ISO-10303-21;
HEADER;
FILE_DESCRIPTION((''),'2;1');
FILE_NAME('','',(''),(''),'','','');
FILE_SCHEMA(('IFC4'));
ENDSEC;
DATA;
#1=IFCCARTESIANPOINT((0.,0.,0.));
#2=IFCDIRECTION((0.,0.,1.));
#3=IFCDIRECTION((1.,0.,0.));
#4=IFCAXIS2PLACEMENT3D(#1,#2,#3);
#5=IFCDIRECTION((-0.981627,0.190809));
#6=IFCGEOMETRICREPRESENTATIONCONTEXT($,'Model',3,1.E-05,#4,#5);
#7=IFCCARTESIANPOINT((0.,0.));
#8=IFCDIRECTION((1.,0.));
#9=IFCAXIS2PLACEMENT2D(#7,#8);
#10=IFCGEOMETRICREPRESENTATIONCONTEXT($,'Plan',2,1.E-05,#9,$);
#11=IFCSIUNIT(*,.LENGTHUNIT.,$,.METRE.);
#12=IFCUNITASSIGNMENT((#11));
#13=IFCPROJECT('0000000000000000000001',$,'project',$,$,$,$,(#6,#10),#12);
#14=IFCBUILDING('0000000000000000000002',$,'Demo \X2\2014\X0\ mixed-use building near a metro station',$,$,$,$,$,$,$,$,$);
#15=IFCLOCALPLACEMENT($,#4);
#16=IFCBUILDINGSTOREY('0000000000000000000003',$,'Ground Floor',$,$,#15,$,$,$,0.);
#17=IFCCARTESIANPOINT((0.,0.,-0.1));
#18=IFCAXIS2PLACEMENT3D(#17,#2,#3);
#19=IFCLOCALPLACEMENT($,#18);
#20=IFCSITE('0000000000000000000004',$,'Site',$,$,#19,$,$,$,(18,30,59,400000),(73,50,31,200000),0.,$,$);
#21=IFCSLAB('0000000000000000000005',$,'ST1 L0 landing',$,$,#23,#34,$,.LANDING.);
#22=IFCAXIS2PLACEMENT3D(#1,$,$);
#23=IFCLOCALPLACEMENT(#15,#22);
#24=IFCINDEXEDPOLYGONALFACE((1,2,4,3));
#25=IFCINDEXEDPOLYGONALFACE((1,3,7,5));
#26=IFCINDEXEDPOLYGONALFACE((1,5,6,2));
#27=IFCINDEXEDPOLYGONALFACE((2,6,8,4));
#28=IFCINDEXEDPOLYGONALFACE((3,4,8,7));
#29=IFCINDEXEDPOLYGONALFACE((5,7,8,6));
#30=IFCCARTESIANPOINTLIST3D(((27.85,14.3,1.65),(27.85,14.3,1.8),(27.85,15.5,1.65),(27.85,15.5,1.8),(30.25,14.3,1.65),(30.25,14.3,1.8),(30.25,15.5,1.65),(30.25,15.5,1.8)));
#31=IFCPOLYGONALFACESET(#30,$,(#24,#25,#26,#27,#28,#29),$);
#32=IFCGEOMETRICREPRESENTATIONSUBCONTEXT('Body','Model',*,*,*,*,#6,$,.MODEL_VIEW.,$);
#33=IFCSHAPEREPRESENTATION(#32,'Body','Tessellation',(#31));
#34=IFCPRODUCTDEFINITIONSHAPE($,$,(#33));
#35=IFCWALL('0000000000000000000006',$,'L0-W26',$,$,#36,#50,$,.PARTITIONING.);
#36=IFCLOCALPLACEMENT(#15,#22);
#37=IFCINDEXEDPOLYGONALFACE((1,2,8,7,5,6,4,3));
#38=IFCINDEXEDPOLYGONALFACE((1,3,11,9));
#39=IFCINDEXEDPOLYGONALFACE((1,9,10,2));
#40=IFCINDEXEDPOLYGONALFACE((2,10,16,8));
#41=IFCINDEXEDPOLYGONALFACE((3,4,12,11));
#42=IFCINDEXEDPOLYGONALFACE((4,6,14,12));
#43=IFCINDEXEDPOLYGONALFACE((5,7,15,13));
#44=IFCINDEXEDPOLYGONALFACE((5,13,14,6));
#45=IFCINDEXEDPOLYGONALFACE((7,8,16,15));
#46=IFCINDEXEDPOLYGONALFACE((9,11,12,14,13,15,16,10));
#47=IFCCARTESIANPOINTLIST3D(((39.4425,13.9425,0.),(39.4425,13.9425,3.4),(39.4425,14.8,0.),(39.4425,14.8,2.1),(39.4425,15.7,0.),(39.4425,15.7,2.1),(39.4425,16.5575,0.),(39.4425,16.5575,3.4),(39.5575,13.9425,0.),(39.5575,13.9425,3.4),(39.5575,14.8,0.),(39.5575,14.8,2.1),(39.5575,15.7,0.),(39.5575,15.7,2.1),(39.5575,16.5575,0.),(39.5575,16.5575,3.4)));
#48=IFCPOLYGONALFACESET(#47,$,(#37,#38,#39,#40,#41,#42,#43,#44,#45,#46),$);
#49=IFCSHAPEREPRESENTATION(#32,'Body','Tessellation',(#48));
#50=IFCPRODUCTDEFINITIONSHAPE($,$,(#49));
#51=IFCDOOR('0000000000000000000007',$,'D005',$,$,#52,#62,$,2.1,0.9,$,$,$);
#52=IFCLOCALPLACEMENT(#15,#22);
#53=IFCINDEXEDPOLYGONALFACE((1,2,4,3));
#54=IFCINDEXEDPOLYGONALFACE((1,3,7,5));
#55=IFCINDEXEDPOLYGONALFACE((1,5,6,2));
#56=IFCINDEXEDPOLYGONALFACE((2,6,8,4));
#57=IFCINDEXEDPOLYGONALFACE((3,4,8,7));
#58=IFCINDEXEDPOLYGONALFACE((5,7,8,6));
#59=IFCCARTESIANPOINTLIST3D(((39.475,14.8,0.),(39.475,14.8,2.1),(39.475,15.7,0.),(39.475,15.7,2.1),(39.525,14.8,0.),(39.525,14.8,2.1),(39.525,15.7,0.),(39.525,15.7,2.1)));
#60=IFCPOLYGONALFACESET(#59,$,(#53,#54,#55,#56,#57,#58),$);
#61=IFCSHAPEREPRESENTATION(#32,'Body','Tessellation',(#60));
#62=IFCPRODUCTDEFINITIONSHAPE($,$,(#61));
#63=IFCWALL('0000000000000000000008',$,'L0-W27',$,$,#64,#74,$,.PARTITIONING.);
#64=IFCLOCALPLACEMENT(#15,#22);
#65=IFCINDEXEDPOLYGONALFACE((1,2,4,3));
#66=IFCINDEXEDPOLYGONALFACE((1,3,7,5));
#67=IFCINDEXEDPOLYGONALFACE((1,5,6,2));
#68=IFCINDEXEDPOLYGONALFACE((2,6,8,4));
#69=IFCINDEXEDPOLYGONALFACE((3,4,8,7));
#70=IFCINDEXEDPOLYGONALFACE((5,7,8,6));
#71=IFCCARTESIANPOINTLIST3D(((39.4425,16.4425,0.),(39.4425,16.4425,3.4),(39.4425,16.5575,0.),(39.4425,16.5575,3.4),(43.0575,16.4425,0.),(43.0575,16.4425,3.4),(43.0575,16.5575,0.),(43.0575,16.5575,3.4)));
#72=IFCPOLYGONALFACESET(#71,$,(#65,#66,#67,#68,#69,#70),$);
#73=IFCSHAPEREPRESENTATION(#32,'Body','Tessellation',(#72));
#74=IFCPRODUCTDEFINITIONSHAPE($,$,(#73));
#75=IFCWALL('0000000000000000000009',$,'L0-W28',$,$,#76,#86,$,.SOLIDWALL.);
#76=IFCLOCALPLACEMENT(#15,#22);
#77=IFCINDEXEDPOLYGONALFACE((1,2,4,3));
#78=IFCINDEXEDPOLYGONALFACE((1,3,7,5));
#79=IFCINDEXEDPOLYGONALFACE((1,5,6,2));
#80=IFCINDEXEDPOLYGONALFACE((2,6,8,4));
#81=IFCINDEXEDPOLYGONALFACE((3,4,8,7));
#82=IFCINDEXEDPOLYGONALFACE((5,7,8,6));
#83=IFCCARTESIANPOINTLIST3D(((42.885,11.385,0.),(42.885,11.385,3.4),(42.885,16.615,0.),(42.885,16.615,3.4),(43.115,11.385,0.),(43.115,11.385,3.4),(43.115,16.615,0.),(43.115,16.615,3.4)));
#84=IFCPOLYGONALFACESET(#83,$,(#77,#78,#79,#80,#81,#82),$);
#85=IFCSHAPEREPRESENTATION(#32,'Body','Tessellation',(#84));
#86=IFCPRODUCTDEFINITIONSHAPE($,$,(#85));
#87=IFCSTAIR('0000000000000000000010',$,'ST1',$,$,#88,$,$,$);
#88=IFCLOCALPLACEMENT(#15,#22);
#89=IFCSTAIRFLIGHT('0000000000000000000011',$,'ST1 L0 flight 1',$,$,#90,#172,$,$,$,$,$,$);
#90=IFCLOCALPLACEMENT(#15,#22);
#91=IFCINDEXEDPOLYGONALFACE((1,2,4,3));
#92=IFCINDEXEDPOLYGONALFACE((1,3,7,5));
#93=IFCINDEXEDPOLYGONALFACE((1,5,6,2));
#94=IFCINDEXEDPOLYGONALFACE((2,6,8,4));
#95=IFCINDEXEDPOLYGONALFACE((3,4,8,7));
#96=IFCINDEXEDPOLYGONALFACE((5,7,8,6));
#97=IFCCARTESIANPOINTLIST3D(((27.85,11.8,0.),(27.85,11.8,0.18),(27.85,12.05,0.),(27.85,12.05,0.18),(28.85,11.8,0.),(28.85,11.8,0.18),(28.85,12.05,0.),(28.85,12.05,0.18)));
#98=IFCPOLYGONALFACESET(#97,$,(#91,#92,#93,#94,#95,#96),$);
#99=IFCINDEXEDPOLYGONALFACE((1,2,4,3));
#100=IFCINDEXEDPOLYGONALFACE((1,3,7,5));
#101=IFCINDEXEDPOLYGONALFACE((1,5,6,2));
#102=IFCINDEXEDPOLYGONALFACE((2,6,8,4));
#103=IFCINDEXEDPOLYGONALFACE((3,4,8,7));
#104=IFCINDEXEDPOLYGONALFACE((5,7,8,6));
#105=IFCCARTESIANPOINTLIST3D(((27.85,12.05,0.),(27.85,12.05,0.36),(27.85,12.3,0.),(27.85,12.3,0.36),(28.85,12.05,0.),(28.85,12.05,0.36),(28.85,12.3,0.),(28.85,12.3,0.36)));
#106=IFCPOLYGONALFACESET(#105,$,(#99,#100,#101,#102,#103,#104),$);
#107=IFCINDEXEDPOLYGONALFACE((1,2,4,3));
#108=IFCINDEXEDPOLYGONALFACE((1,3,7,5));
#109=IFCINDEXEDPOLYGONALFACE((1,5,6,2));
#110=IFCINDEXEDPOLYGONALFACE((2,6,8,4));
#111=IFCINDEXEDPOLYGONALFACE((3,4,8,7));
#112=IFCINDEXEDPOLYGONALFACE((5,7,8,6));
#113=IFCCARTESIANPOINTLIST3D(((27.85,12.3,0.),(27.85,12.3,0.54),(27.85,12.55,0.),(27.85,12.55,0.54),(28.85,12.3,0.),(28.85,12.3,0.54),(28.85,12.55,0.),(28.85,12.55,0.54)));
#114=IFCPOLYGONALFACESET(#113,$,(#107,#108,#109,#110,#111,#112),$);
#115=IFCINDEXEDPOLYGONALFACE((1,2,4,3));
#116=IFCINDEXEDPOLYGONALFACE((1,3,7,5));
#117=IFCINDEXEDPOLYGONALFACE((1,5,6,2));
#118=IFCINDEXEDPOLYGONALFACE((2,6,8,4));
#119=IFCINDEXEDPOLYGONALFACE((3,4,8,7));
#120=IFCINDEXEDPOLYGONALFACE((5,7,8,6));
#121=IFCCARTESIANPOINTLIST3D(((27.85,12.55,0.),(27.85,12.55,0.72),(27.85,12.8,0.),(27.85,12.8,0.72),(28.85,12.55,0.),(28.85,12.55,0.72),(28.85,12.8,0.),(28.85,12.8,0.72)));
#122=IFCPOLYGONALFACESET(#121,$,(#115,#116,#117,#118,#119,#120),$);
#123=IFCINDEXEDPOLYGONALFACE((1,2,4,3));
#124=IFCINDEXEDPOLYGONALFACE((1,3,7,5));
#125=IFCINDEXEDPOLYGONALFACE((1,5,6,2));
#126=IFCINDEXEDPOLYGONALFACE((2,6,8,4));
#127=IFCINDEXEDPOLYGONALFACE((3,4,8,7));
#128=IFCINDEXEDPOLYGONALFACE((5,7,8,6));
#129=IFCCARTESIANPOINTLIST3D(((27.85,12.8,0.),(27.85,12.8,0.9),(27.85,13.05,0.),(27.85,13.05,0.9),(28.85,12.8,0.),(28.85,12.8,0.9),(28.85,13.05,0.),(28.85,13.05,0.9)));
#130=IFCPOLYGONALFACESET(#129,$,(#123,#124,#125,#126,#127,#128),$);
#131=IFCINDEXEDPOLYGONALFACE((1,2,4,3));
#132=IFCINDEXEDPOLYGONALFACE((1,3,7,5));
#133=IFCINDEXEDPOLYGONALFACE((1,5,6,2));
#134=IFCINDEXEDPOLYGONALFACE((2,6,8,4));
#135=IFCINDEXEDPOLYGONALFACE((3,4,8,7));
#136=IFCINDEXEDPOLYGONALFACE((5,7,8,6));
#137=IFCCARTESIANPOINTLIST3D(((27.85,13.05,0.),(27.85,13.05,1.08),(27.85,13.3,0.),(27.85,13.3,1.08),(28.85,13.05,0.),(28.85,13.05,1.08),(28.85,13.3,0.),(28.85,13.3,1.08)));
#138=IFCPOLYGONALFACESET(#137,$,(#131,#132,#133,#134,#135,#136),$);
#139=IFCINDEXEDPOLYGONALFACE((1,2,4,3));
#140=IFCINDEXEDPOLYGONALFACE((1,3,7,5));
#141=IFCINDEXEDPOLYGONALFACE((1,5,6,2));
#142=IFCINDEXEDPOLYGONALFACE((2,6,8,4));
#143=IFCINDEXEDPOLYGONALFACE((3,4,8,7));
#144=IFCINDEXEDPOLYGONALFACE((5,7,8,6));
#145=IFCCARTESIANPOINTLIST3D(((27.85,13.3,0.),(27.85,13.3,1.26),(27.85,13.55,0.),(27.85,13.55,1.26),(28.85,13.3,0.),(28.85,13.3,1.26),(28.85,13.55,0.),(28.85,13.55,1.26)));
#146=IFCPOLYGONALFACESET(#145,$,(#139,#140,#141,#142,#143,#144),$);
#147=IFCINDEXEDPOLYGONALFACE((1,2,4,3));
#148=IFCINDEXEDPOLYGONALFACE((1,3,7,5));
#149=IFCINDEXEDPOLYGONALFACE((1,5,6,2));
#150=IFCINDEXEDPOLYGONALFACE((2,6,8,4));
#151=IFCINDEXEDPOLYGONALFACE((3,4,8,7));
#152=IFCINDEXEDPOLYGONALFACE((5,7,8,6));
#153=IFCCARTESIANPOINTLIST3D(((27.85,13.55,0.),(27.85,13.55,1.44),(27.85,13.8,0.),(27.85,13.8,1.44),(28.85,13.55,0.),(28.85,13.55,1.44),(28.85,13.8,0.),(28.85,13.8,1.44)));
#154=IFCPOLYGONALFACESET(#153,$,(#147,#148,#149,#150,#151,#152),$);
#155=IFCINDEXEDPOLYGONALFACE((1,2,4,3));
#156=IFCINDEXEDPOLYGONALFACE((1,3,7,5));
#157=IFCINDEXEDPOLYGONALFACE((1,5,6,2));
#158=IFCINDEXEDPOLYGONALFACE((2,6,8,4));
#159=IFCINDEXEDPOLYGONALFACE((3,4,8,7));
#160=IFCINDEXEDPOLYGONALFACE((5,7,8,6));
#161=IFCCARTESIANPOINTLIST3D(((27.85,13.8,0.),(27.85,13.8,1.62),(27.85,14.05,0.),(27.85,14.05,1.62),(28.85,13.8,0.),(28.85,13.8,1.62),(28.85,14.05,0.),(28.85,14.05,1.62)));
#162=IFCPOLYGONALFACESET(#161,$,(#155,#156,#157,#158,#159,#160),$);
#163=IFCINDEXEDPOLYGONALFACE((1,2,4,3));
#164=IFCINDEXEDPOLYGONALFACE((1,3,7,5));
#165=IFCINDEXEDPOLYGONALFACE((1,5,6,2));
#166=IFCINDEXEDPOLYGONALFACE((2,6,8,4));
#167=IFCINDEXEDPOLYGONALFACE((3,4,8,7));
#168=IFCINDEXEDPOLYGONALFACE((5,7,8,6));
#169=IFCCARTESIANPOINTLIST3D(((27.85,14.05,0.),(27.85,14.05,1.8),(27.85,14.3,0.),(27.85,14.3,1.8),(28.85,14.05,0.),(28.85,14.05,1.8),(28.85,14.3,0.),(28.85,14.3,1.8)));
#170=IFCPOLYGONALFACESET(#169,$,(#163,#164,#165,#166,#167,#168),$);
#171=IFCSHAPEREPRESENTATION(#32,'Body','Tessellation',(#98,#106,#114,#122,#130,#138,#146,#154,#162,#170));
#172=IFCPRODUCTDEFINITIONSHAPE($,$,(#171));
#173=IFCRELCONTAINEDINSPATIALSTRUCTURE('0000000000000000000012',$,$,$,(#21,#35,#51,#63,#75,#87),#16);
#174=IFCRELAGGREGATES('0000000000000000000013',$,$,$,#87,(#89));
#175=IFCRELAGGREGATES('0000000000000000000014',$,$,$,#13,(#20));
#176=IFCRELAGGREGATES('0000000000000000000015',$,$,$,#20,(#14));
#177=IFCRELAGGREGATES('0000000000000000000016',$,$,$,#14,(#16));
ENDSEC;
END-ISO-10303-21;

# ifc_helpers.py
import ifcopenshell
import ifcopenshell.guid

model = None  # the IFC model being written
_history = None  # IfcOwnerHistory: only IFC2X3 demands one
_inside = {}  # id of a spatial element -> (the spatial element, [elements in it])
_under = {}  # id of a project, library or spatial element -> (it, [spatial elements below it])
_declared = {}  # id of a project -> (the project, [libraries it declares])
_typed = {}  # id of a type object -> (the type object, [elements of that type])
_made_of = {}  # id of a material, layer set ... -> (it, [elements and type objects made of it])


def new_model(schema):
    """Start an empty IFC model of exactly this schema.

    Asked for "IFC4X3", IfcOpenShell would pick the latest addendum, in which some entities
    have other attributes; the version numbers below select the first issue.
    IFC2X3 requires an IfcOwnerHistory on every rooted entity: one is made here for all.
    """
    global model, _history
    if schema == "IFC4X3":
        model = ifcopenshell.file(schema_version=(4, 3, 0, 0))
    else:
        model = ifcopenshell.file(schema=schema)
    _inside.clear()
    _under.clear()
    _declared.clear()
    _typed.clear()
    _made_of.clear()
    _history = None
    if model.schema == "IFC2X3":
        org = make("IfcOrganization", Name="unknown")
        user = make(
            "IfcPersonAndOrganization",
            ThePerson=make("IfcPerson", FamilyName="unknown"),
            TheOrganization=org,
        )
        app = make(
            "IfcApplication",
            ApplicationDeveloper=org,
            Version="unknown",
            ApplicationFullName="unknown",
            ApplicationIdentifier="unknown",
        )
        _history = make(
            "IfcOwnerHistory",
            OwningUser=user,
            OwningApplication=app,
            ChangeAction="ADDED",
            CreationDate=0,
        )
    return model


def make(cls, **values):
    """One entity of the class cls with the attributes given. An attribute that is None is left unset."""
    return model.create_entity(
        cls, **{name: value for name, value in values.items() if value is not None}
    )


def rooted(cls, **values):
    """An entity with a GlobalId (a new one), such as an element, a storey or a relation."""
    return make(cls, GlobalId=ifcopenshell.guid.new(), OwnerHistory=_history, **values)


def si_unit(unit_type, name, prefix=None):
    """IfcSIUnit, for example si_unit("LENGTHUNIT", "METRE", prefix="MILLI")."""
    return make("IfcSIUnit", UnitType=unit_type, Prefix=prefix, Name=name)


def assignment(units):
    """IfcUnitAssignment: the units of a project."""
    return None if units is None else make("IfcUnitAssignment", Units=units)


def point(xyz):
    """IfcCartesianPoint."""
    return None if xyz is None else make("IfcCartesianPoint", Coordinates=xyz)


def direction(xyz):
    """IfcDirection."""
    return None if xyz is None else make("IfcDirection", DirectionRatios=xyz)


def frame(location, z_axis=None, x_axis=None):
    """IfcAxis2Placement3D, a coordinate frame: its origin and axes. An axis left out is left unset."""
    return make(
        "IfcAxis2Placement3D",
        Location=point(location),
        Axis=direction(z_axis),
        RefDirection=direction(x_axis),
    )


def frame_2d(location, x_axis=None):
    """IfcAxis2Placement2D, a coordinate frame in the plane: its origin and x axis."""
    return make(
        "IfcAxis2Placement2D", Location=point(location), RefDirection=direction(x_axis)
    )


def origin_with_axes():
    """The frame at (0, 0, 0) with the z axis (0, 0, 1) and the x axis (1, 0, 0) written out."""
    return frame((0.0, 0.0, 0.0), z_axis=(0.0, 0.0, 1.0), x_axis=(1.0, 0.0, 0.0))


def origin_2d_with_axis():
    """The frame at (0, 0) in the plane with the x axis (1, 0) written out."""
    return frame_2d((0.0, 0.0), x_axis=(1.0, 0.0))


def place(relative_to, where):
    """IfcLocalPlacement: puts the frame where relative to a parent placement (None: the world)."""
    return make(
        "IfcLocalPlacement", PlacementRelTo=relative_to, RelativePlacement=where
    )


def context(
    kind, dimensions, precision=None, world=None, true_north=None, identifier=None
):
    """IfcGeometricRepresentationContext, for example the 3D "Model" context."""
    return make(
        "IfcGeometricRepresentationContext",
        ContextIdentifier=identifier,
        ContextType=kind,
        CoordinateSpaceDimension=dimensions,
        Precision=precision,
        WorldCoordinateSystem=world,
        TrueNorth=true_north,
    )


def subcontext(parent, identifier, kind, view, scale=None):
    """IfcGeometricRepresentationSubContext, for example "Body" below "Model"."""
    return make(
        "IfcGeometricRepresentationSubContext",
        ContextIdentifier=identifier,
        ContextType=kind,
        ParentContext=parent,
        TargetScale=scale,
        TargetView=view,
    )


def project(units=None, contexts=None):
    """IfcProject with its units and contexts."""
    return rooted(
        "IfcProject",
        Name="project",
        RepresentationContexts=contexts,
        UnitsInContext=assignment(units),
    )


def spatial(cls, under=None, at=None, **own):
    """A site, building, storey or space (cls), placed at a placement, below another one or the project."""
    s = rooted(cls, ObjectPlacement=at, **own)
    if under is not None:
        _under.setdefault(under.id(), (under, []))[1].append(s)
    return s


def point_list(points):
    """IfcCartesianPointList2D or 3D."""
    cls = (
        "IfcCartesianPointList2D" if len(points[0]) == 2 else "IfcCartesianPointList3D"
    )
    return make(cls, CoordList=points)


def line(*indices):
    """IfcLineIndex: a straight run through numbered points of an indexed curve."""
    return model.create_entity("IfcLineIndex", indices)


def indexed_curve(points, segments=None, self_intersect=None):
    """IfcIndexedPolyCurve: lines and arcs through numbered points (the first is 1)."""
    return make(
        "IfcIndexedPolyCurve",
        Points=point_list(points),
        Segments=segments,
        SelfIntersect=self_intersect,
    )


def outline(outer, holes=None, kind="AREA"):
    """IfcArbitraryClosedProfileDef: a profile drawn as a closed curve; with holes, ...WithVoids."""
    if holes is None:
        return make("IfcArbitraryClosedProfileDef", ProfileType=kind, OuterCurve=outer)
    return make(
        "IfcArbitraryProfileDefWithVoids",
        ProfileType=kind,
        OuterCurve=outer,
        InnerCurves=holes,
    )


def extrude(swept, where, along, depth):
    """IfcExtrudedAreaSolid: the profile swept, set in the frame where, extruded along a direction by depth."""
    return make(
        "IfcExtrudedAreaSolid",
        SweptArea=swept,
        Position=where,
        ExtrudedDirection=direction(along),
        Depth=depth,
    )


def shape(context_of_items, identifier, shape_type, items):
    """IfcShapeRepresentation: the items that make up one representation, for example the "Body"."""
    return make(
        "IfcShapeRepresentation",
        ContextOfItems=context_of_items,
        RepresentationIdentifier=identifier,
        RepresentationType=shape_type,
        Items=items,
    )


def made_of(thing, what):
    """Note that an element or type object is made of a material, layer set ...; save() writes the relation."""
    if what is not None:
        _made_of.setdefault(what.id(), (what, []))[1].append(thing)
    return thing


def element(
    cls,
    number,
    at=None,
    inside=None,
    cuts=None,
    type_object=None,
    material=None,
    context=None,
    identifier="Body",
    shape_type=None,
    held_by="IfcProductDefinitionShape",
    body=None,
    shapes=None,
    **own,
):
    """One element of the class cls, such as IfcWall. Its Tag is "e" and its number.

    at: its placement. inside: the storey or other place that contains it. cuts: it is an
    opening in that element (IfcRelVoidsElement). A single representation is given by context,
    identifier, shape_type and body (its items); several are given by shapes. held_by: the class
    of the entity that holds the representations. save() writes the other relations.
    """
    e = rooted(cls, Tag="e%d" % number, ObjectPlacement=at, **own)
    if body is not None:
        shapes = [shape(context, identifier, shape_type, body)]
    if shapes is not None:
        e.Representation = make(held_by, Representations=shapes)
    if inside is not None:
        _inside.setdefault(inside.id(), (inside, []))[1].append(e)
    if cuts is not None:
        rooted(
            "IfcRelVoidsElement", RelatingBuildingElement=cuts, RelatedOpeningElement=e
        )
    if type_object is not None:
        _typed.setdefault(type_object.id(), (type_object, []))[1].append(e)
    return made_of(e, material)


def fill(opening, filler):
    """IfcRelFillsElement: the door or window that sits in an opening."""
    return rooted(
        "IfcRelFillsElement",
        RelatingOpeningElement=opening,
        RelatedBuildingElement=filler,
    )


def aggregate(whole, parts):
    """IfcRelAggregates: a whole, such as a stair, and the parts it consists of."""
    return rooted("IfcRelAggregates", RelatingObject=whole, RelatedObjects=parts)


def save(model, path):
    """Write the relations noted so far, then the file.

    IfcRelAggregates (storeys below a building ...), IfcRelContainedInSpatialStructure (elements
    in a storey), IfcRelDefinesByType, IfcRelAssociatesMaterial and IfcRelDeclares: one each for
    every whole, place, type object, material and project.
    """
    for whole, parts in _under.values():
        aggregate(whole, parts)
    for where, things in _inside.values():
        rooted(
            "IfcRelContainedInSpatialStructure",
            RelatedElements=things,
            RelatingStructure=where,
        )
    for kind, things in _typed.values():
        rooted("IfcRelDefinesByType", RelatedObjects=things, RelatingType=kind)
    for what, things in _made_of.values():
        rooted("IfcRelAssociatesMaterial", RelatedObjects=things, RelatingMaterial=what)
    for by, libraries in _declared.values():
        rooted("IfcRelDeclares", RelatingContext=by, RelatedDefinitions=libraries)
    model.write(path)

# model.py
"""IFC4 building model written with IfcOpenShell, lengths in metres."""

from ifc_helpers import new_model, si_unit, direction, frame, origin_with_axes, origin_2d_with_axis, place, context, subcontext, project, spatial, line, indexed_curve, outline, extrude, element, fill, aggregate, save


model = new_model("IFC4")

# Units and contexts
model_context = context("Model", 3, precision=1e-05, world=origin_with_axes(), true_north=direction((-0.981627, 0.190809)))
plan_context = context("Plan", 2, precision=1e-05, world=origin_2d_with_axis())
body_context = subcontext(model_context, "Body", "Model", "MODEL_VIEW")
ifc_project = project(units=[si_unit("LENGTHUNIT", "METRE")], contexts=[model_context, plan_context])

# Site, building, storey
site_placement = place(None, frame((0.0, 0.0, -0.1), z_axis=(0.0, 0.0, 1.0), x_axis=(1.0, 0.0, 0.0)))
site = spatial("IfcSite", under=ifc_project, at=site_placement, Name="Site", RefLatitude=(18, 30, 59, 400000), RefLongitude=(73, 50, 31, 200000), RefElevation=0.0)
building = spatial("IfcBuilding", under=site, Name="Demo — mixed-use building near a metro station")
storey_placement = place(None, origin_with_axes())
storey = spatial("IfcBuildingStorey", under=building, at=storey_placement, Name="Ground Floor", Elevation=0.0)

# Slab
slab_placement = place(storey_placement, origin_with_axes())
element("IfcSlab", 1, at=slab_placement, inside=storey, Name="ST1 L0 landing", PredefinedType="LANDING", context=body_context, shape_type="SweptSolid", body=[
    extrude(outline(indexed_curve([(27.85, 14.3), (30.25, 14.3), (30.25, 15.5), (27.85, 15.5)], segments=[line(1, 2, 3, 4, 1)])), frame((0.0, 0.0, 1.65), z_axis=(0.0, 0.0, 1.0), x_axis=(1.0, 0.0, 0.0)), (0.0, 0.0, 1.0), 0.15),
])

# Wall, opening, door
wall_1_placement = place(storey_placement, origin_with_axes())
wall_1 = element("IfcWall", 2, at=wall_1_placement, inside=storey, Name="L0-W26", PredefinedType="PARTITIONING", context=body_context, shape_type="SweptSolid", body=[
    extrude(outline(indexed_curve([(39.4425, 13.9425), (39.4425, 16.5575), (39.5575, 16.5575), (39.5575, 13.9425)], segments=[line(1, 2, 3, 4, 1)])), origin_with_axes(), (0.0, 0.0, 1.0), 3.4),
])
opening_placement = place(wall_1_placement, origin_with_axes())
opening = element("IfcOpeningElement", 3, at=opening_placement, cuts=wall_1, context=body_context, shape_type="SweptSolid", body=[
    extrude(outline(indexed_curve([(39.3925, 14.8), (39.3925, 15.7), (39.6075, 15.7), (39.6075, 14.8)], segments=[line(1, 2, 3, 4, 1)])), origin_with_axes(), (0.0, 0.0, 1.0), 2.1),
])
door_placement = place(storey_placement, origin_with_axes())
door = element("IfcDoor", 4, at=door_placement, inside=storey, Name="D005", OverallHeight=2.1, OverallWidth=0.9, context=body_context, shape_type="SweptSolid", body=[
    extrude(outline(indexed_curve([(39.475, 14.8), (39.475, 15.7), (39.525, 15.7), (39.525, 14.8)], segments=[line(1, 2, 3, 4, 1)])), origin_with_axes(), (0.0, 0.0, 1.0), 2.1),
])
fill(opening, door)

# Walls
wall_2_placement = place(storey_placement, origin_with_axes())
element("IfcWall", 5, at=wall_2_placement, inside=storey, Name="L0-W27", PredefinedType="PARTITIONING", context=body_context, shape_type="SweptSolid", body=[
    extrude(outline(indexed_curve([(43.0575, 16.4425), (39.4425, 16.4425), (39.4425, 16.5575), (43.0575, 16.5575)], segments=[line(1, 2, 3, 4, 1)])), origin_with_axes(), (0.0, 0.0, 1.0), 3.4),
])
wall_3_placement = place(storey_placement, origin_with_axes())
element("IfcWall", 6, at=wall_3_placement, inside=storey, Name="L0-W28", PredefinedType="SOLIDWALL", context=body_context, shape_type="SweptSolid", body=[
    extrude(outline(indexed_curve([(42.885, 11.385), (42.885, 16.615), (43.115, 16.615), (43.115, 11.385)], segments=[line(1, 2, 3, 4, 1)])), origin_with_axes(), (0.0, 0.0, 1.0), 3.4),
])

# Stair, stair flight
stair = element("IfcStair", 7, inside=storey, Name="ST1")
stair_flight_1_placement = place(None, origin_with_axes())
stair_flight_1 = element("IfcStairFlight", 8, at=stair_flight_1_placement, Name="ST1 L0 flight 1", context=body_context, shape_type="SweptSolid", body=[
    extrude(outline(indexed_curve([(27.85, 11.8), (28.85, 11.8), (28.85, 12.05), (27.85, 12.05)], segments=[line(1, 2, 3, 4, 1)])), origin_with_axes(), (0.0, 0.0, 1.0), 0.18),
    extrude(outline(indexed_curve([(27.85, 12.05), (28.85, 12.05), (28.85, 12.3), (27.85, 12.3)], segments=[line(1, 2, 3, 4, 1)])), origin_with_axes(), (0.0, 0.0, 1.0), 0.36),
    extrude(outline(indexed_curve([(27.85, 12.3), (28.85, 12.3), (28.85, 12.55), (27.85, 12.55)], segments=[line(1, 2, 3, 4, 1)])), origin_with_axes(), (0.0, 0.0, 1.0), 0.54),
    extrude(outline(indexed_curve([(27.85, 12.55), (28.85, 12.55), (28.85, 12.8), (27.85, 12.8)], segments=[line(1, 2, 3, 4, 1)])), origin_with_axes(), (0.0, 0.0, 1.0), 0.72),
    extrude(outline(indexed_curve([(27.85, 12.8), (28.85, 12.8), (28.85, 13.05), (27.85, 13.05)], segments=[line(1, 2, 3, 4, 1)])), origin_with_axes(), (0.0, 0.0, 1.0), 0.9),
    extrude(outline(indexed_curve([(27.85, 13.05), (28.85, 13.05), (28.85, 13.3), (27.85, 13.3)], segments=[line(1, 2, 3, 4, 1)])), origin_with_axes(), (0.0, 0.0, 1.0), 1.08),
    extrude(outline(indexed_curve([(27.85, 13.3), (28.85, 13.3), (28.85, 13.55), (27.85, 13.55)], segments=[line(1, 2, 3, 4, 1)])), origin_with_axes(), (0.0, 0.0, 1.0), 1.26),
    extrude(outline(indexed_curve([(27.85, 13.55), (28.85, 13.55), (28.85, 13.8), (27.85, 13.8)], segments=[line(1, 2, 3, 4, 1)])), origin_with_axes(), (0.0, 0.0, 1.0), 1.44),
    extrude(outline(indexed_curve([(27.85, 13.8), (28.85, 13.8), (28.85, 14.05), (27.85, 14.05)], segments=[line(1, 2, 3, 4, 1)])), origin_with_axes(), (0.0, 0.0, 1.0), 1.62),
    extrude(outline(indexed_curve([(27.85, 14.05), (28.85, 14.05), (28.85, 14.3), (27.85, 14.3)], segments=[line(1, 2, 3, 4, 1)])), origin_with_axes(), (0.0, 0.0, 1.0), 1.8),
])
aggregate(stair, [stair_flight_1])

save(model, "model.ifc")
